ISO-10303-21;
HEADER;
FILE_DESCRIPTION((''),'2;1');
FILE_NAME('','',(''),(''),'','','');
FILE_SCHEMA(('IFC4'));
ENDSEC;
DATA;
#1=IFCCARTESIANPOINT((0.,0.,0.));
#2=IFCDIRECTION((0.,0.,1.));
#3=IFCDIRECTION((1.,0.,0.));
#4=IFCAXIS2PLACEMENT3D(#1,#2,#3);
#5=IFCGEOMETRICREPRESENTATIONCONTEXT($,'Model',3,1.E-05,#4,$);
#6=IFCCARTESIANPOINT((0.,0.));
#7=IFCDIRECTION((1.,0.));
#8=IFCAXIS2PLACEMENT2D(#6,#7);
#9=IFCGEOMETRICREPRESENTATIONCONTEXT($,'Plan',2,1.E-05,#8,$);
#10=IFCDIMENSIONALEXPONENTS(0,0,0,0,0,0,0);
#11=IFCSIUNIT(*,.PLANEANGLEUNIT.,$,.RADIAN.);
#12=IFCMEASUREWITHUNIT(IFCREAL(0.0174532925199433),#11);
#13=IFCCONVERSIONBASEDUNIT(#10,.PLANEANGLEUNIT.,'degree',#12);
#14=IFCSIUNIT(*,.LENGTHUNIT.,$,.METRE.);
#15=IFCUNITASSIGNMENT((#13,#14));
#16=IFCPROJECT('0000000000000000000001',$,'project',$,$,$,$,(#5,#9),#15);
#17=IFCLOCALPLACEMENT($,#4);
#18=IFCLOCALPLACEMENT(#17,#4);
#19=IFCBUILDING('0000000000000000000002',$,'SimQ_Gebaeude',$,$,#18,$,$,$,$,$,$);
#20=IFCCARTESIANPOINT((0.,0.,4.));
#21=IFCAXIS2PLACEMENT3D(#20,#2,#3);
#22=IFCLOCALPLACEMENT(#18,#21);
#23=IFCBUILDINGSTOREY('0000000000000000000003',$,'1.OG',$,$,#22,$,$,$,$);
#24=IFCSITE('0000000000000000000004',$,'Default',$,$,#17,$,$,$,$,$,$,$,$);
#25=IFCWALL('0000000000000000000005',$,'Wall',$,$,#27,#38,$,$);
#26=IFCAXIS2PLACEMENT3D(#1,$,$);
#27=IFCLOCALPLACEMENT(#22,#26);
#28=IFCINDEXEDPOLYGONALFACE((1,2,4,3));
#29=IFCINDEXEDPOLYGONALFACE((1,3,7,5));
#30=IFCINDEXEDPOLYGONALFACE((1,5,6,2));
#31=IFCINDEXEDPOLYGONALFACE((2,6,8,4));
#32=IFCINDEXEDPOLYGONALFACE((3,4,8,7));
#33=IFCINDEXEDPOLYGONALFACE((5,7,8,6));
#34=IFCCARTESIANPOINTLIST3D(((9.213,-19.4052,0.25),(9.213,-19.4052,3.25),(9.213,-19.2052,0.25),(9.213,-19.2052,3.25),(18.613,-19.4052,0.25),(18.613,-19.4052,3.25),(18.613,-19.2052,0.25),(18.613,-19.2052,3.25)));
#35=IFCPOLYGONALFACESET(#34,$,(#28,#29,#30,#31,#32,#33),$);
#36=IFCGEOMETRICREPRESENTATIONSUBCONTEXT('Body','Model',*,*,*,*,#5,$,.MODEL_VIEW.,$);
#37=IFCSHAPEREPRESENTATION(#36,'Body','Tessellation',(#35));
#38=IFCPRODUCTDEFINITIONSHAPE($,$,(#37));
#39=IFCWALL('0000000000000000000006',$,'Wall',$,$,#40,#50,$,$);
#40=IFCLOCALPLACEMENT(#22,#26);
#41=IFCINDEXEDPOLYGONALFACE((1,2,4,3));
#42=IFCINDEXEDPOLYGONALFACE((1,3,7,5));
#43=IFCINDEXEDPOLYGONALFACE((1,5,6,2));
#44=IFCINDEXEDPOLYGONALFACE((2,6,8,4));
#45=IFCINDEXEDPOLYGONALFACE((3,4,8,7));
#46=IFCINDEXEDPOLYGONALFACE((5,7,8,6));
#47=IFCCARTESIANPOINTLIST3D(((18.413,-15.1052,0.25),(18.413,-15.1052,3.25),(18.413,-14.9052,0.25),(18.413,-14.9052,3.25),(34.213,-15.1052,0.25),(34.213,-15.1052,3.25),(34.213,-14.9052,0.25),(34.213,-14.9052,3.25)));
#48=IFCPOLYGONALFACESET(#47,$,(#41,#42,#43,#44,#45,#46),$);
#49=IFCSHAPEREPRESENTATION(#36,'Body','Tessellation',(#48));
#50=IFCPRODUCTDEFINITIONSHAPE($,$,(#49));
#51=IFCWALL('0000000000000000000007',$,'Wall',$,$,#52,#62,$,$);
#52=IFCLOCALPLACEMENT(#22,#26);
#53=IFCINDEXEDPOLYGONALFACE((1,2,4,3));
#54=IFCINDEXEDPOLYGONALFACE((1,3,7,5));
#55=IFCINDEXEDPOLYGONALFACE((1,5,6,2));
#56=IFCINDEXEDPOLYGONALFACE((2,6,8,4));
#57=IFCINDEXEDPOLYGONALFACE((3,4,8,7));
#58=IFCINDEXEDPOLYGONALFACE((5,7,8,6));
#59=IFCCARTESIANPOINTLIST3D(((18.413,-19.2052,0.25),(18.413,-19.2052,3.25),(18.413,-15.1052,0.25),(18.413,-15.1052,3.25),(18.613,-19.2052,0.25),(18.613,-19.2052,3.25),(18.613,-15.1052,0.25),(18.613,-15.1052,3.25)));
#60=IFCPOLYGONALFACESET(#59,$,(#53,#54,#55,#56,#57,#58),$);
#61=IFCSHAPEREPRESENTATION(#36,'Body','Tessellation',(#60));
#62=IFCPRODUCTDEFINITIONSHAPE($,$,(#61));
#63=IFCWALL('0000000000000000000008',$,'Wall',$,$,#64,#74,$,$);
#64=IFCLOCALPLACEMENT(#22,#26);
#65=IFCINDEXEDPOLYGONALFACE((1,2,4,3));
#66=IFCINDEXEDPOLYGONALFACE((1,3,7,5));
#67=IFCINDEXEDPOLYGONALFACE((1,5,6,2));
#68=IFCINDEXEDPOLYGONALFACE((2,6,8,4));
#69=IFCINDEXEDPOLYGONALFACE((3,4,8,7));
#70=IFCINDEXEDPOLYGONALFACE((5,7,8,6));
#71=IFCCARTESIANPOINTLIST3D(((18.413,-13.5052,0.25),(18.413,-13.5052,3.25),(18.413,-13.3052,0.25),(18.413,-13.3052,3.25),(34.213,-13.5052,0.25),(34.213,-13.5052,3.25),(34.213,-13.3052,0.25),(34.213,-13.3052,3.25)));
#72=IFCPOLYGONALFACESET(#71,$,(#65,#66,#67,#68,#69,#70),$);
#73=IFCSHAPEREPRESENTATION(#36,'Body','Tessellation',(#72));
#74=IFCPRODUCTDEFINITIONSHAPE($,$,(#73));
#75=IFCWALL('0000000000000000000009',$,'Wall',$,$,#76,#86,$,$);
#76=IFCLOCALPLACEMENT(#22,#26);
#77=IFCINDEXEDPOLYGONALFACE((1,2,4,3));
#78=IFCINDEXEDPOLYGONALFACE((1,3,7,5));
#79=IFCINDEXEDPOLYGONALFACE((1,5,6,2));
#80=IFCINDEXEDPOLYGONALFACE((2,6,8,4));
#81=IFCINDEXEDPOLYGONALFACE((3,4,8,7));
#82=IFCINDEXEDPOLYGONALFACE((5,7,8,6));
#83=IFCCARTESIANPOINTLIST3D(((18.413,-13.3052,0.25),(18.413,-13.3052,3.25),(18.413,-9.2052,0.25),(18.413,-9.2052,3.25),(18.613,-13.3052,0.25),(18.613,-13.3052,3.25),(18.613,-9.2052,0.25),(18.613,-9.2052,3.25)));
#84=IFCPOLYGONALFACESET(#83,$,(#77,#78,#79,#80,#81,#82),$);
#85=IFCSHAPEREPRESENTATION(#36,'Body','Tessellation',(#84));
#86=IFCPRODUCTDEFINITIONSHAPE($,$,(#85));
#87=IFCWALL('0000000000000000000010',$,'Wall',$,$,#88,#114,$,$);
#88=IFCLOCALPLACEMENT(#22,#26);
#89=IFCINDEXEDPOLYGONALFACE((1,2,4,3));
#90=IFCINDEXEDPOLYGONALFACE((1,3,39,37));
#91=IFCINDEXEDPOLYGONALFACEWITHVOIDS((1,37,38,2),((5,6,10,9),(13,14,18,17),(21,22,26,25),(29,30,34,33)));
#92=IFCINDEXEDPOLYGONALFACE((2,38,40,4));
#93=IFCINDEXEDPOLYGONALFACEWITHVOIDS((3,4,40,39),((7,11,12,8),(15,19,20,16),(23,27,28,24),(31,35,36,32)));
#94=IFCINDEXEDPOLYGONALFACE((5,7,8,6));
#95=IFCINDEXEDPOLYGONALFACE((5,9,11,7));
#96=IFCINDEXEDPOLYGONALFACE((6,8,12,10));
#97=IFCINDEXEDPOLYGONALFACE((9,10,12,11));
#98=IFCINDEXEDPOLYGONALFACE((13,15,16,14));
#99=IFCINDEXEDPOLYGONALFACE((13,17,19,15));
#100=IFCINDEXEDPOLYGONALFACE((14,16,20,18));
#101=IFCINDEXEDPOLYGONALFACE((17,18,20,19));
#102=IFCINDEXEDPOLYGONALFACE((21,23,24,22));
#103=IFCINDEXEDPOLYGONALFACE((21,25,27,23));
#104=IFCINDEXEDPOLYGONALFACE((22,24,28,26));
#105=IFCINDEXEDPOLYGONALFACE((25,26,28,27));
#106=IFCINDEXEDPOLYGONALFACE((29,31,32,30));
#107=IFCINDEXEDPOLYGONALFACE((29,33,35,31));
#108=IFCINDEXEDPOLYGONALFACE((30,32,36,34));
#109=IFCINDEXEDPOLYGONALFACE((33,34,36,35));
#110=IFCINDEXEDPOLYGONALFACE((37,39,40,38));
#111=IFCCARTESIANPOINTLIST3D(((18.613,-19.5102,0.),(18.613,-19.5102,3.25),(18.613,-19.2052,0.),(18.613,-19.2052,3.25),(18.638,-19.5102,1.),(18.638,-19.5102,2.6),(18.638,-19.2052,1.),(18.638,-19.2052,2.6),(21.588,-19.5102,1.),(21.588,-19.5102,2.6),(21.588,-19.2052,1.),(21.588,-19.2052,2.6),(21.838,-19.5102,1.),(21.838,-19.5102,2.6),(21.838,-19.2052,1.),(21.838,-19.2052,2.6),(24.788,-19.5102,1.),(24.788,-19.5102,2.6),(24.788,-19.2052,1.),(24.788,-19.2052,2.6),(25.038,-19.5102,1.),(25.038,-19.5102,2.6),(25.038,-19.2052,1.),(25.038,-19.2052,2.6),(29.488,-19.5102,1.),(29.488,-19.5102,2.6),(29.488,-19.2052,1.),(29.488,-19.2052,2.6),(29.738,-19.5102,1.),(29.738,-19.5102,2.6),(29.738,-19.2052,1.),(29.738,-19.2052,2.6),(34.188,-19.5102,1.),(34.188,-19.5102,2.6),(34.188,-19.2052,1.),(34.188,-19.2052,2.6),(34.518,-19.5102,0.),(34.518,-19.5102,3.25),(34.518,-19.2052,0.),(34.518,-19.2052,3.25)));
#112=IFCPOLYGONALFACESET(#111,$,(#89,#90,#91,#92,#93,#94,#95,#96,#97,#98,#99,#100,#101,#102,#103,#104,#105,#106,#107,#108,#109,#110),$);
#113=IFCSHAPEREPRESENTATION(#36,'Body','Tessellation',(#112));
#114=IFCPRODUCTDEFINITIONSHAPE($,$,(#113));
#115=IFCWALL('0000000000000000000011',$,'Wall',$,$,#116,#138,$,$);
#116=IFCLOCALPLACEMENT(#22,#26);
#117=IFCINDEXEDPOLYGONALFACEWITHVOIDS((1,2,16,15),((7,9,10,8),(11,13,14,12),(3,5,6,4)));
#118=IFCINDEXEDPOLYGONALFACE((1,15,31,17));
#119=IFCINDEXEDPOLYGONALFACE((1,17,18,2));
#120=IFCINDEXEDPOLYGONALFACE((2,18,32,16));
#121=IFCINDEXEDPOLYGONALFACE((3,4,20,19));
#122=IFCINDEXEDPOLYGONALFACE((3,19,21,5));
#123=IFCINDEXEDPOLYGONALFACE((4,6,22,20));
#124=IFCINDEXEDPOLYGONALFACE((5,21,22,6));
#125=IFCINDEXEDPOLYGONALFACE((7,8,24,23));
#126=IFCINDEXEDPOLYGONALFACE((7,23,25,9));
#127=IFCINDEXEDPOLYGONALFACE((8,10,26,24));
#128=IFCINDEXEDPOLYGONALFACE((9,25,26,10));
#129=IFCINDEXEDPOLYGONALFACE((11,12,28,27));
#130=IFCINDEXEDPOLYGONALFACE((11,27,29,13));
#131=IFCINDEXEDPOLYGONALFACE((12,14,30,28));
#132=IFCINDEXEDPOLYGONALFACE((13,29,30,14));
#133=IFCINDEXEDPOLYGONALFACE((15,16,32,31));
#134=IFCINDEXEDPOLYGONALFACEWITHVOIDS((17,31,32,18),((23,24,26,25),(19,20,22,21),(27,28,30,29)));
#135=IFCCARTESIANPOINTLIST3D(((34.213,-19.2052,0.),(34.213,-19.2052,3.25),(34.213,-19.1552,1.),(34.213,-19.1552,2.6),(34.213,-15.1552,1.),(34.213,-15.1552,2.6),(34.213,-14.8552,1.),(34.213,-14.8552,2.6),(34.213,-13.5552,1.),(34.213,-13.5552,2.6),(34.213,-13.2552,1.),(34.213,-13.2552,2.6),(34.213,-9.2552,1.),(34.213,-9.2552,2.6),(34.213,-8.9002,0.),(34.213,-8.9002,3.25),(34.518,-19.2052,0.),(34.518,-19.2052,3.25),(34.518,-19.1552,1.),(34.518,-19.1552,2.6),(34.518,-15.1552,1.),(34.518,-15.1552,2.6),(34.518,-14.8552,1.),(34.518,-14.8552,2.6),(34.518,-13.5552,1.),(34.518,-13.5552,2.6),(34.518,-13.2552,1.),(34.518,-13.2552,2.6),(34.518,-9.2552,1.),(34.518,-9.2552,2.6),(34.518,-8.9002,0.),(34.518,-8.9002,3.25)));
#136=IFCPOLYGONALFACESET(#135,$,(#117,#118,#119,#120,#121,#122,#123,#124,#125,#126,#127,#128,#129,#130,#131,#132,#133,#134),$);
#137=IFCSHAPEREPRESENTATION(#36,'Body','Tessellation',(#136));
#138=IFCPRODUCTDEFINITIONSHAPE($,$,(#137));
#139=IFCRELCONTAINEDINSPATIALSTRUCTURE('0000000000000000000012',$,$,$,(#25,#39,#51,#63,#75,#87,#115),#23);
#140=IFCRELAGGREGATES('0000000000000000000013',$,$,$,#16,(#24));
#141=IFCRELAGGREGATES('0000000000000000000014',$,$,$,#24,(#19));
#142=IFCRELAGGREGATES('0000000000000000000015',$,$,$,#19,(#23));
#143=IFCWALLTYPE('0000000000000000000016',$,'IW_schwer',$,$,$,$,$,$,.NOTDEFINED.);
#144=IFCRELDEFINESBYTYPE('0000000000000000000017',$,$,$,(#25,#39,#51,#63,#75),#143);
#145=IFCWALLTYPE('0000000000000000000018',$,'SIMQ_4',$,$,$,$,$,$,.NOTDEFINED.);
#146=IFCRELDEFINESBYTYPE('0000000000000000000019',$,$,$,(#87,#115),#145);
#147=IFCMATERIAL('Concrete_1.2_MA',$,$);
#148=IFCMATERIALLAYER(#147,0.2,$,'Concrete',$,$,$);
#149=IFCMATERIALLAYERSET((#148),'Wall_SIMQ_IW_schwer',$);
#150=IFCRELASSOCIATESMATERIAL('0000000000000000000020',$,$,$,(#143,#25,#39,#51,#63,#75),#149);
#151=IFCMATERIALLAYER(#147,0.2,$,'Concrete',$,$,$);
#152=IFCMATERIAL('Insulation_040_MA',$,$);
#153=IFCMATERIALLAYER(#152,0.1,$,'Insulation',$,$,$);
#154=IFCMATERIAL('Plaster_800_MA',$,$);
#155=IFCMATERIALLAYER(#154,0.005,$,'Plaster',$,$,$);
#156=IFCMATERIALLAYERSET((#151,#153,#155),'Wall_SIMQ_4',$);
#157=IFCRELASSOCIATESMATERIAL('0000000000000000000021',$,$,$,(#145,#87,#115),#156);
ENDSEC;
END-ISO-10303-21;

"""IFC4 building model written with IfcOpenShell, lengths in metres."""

from ifc_helpers import new_model, entity, si_unit, converted_unit, frame, origin_with_axes, origin_2d_with_axis, place, context, subcontext, project, spatial, line, indexed_curve, outline, extrude, source, transform, mapped, material, layer, layer_set, layer_usage, type_object, element, save


model = new_model("IFC4")

# Units and contexts
model_context = context("Model", 3, precision=1e-05, world=origin_with_axes())
plan_context = context("Plan", 2, precision=1e-05, world=origin_2d_with_axis())
body_context = subcontext(model_context, "Body", "Model", "MODEL_VIEW")
ifc_project = project(units=[converted_unit("PLANEANGLEUNIT", "degree", entity("IfcReal", 0.0174532925199433), si_unit("PLANEANGLEUNIT", "RADIAN"), dimensions=[0, 0, 0, 0, 0, 0, 0]), si_unit("LENGTHUNIT", "METRE")], contexts=[model_context, plan_context])

# Site, building, storey
site_placement = place(None, origin_with_axes())
site = spatial("IfcSite", under=ifc_project, at=site_placement, Name="Default")
building_placement = place(site_placement, origin_with_axes())
building = spatial("IfcBuilding", under=site, at=building_placement, Name="SimQ_Gebaeude")
storey_placement = place(building_placement, frame((0.0, 0.0, 4.0), z_axis=(0.0, 0.0, 1.0), x_axis=(1.0, 0.0, 0.0)))
storey = spatial("IfcBuildingStorey", under=building, at=storey_placement, Name="1.OG")

# Walls
ifc_material_1 = material(Name="Concrete_1.2_MA")
ifc_layer_1 = layer(ifc_material_1, 0.2, Name="Concrete")
ifc_layer_set_1 = layer_set([ifc_layer_1], Name="Wall_SIMQ_IW_schwer")
ifc_layer_usage_1 = layer_usage(ifc_layer_set_1, "AXIS2", "POSITIVE", 0.0)
wall_type_1 = type_object("IfcWallType", Name="IW_schwer", PredefinedType="NOTDEFINED", material=ifc_layer_set_1)
wall_1_placement = place(storey_placement, frame((18.613, -19.2052, 0.25), z_axis=(0.0, 0.0, 1.0), x_axis=(-1.0, 0.0, 0.0)))
element("IfcWall", 1, at=wall_1_placement, inside=storey, type_object=wall_type_1, material=ifc_layer_usage_1, Name="Wall", context=body_context, shape_type="SweptSolid", body=[
    extrude(outline(indexed_curve([(0.0, 0.0), (0.0, 0.2), (9.4, 0.2), (9.4, 0.0), (0.0, 0.0)], self_intersect=False)), origin_with_axes(), (0.0, 0.0, 1.0), 3.0),
])
ifc_layer_usage_2 = layer_usage(ifc_layer_set_1, "AXIS2", "POSITIVE", 0.0)
wall_2_placement = place(storey_placement, frame((34.213, -14.9052, 0.25), z_axis=(0.0, 0.0, 1.0), x_axis=(-1.0, 0.0, 0.0)))
element("IfcWall", 2, at=wall_2_placement, inside=storey, type_object=wall_type_1, material=ifc_layer_usage_2, Name="Wall", context=body_context, shape_type="SweptSolid", body=[
    extrude(outline(indexed_curve([(0.0, 0.0), (0.0, 0.2), (15.8, 0.2), (15.8, 0.0), (0.0, 0.0)], self_intersect=False)), origin_with_axes(), (0.0, 0.0, 1.0), 3.0),
])
ifc_layer_usage_3 = layer_usage(ifc_layer_set_1, "AXIS2", "POSITIVE", 0.0)
wall_3_placement = place(storey_placement, frame((18.613, -19.2052, 0.25), z_axis=(0.0, 0.0, 1.0), x_axis=(0.000001, 1.0, 0.0)))
element("IfcWall", 3, at=wall_3_placement, inside=storey, type_object=wall_type_1, material=ifc_layer_usage_3, Name="Wall", context=body_context, shape_type="SweptSolid", body=[
    extrude(outline(indexed_curve([(0.0, 0.0), (0.0, 0.2), (4.1, 0.2), (4.1, 0.0), (0.0, 0.0)], self_intersect=False)), origin_with_axes(), (0.0, 0.0, 1.0), 3.0),
])
ifc_layer_usage_4 = layer_usage(ifc_layer_set_1, "AXIS2", "POSITIVE", 0.0)
wall_4_placement = place(storey_placement, frame((34.213, -13.3052, 0.25), z_axis=(0.0, 0.0, 1.0), x_axis=(-1.0, 0.0, 0.0)))
element("IfcWall", 4, at=wall_4_placement, inside=storey, type_object=wall_type_1, material=ifc_layer_usage_4, Name="Wall", context=body_context, shape_type="SweptSolid", body=[
    extrude(outline(indexed_curve([(0.0, 0.0), (0.0, 0.2), (15.8, 0.2), (15.8, 0.0), (0.0, 0.0)], self_intersect=False)), origin_with_axes(), (0.0, 0.0, 1.0), 3.0),
])
ifc_layer_usage_5 = layer_usage(ifc_layer_set_1, "AXIS2", "POSITIVE", 0.0)
wall_5_placement = place(storey_placement, frame((18.613, -13.3052, 0.25), z_axis=(0.0, 0.0, 1.0), x_axis=(0.000001, 1.0, 0.0)))
element("IfcWall", 5, at=wall_5_placement, inside=storey, type_object=wall_type_1, material=ifc_layer_usage_5, Name="Wall", context=body_context, shape_type="SweptSolid", body=[
    extrude(outline(indexed_curve([(0.0, 0.0), (0.0, 0.2), (4.1, 0.2), (4.1, 0.0), (0.0, 0.0)], self_intersect=False)), origin_with_axes(), (0.0, 0.0, 1.0), 3.0),
])

# Walls, openings
ifc_layer_2 = layer(ifc_material_1, 0.2, Name="Concrete")
ifc_material_2 = material(Name="Insulation_040_MA")
ifc_layer_3 = layer(ifc_material_2, 0.1, Name="Insulation")
ifc_material_3 = material(Name="Plaster_800_MA")
ifc_layer_4 = layer(ifc_material_3, 0.005, Name="Plaster")
ifc_layer_set_2 = layer_set([ifc_layer_2, ifc_layer_3, ifc_layer_4], Name="Wall_SIMQ_4")
ifc_layer_usage_6 = layer_usage(ifc_layer_set_2, "AXIS2", "POSITIVE", 0.0)
wall_type_2 = type_object("IfcWallType", Name="SIMQ_4", PredefinedType="NOTDEFINED", material=ifc_layer_set_2)
wall_6_placement = place(storey_placement, frame((18.613, -19.5102, 0.0), z_axis=(0.0, 0.0, 1.0), x_axis=(1.0, 0.0, 0.0)))
wall_6 = element("IfcWall", 6, at=wall_6_placement, inside=storey, type_object=wall_type_2, material=ifc_layer_usage_6, Name="Wall", context=body_context, shape_type="SweptSolid", body=[
    extrude(outline(indexed_curve([(0.0, 0.0), (0.0, 0.305), (15.905, 0.305), (15.905, 0.0), (0.0, 0.0)], self_intersect=False)), origin_with_axes(), (0.0, 0.0, 1.0), 3.25),
])
shared_shape_1 = source(origin_with_axes(), body_context, "Body", "SweptSolid", [
    extrude(outline(indexed_curve([(0.0, 0.0), (4.45, 0.0), (4.45, 1.6), (0.0, 1.6)], segments=[line(1, 2, 3, 4, 1)])), frame((0.0, -0.6, 0.0), z_axis=(0.0, -1.0, 0.0), x_axis=(1.0, 0.0, 0.0)), (0.0, 0.0, -1.0), 1.2),
])
opening_1_placement = place(wall_6_placement, frame((11.125, 0.0, 1.0), z_axis=(0.0, 0.0, 1.0), x_axis=(1.0, 0.0, 0.0)))
element("IfcOpeningElement", 7, at=opening_1_placement, cuts=wall_6, PredefinedType="OPENING", context=body_context, shape_type="MappedRepresentation", body=[
    mapped(shared_shape_1, transform((0.0, 0.0, 0.0), x_axis=(1.0, 0.0, 0.0), y_axis=(0.0, 1.0, 0.0), z_axis=(0.0, 0.0, 1.0), scale=1.0)),
])
opening_2_placement = place(wall_6_placement, frame((6.425, 0.0, 1.0), z_axis=(0.0, 0.0, 1.0), x_axis=(1.0, 0.0, 0.0)))
element("IfcOpeningElement", 8, at=opening_2_placement, cuts=wall_6, PredefinedType="OPENING", context=body_context, shape_type="MappedRepresentation", body=[
    mapped(shared_shape_1, transform((0.0, 0.0, 0.0), x_axis=(1.0, 0.0, 0.0), y_axis=(0.0, 1.0, 0.0), z_axis=(0.0, 0.0, 1.0), scale=1.0)),
])
shared_shape_2 = source(origin_with_axes(), body_context, "Body", "SweptSolid", [
    extrude(outline(indexed_curve([(0.0, 0.0), (2.95, 0.0), (2.95, 1.6), (0.0, 1.6)], segments=[line(1, 2, 3, 4, 1)])), frame((0.0, -0.6, 0.0), z_axis=(0.0, -1.0, 0.0), x_axis=(1.0, 0.0, 0.0)), (0.0, 0.0, -1.0), 1.2),
])
opening_3_placement = place(wall_6_placement, frame((3.225, 0.0, 1.0), z_axis=(0.0, 0.0, 1.0), x_axis=(1.0, 0.0, 0.0)))
element("IfcOpeningElement", 9, at=opening_3_placement, cuts=wall_6, PredefinedType="OPENING", context=body_context, shape_type="MappedRepresentation", body=[
    mapped(shared_shape_2, transform((0.0, 0.0, 0.0), x_axis=(1.0, 0.0, 0.0), y_axis=(0.0, 1.0, 0.0), z_axis=(0.0, 0.0, 1.0), scale=1.0)),
])
opening_4_placement = place(wall_6_placement, frame((0.025, 0.0, 1.0), z_axis=(0.0, 0.0, 1.0), x_axis=(1.0, 0.0, 0.0)))
element("IfcOpeningElement", 10, at=opening_4_placement, cuts=wall_6, PredefinedType="OPENING", context=body_context, shape_type="MappedRepresentation", body=[
    mapped(shared_shape_2, transform((0.0, 0.0, 0.0), x_axis=(1.0, 0.0, 0.0), y_axis=(0.0, 1.0, 0.0), z_axis=(0.0, 0.0, 1.0), scale=1.0)),
])
ifc_layer_usage_7 = layer_usage(ifc_layer_set_2, "AXIS2", "POSITIVE", 0.0)
wall_7_placement = place(storey_placement, frame((34.518, -19.2052, 0.0), z_axis=(0.0, 0.0, 1.0), x_axis=(0.0, 1.0, 0.0)))
wall_7 = element("IfcWall", 11, at=wall_7_placement, inside=storey, type_object=wall_type_2, material=ifc_layer_usage_7, Name="Wall", context=body_context, shape_type="SweptSolid", body=[
    extrude(outline(indexed_curve([(0.0, 0.0), (0.0, 0.305), (10.305, 0.305), (10.305, 0.0), (0.0, 0.0)], self_intersect=False)), origin_with_axes(), (0.0, 0.0, 1.0), 3.25),
])
shared_shape_3 = source(origin_with_axes(), body_context, "Body", "SweptSolid", [
    extrude(outline(indexed_curve([(0.0, 0.0), (4.0, 0.0), (4.0, 1.6), (0.0, 1.6)], segments=[line(1, 2, 3, 4, 1)])), frame((0.0, -0.6, 0.0), z_axis=(0.0, -1.0, 0.0), x_axis=(1.0, 0.0, 0.0)), (0.0, 0.0, -1.0), 1.2),
])
opening_5_placement = place(wall_7_placement, frame((0.05, 0.0, 1.0), z_axis=(0.0, 0.0, 1.0), x_axis=(1.0, 0.0, 0.0)))
element("IfcOpeningElement", 12, at=opening_5_placement, cuts=wall_7, PredefinedType="OPENING", context=body_context, shape_type="MappedRepresentation", body=[
    mapped(shared_shape_3, transform((0.0, 0.0, 0.0), x_axis=(1.0, 0.0, 0.0), y_axis=(0.0, 1.0, 0.0), z_axis=(0.0, 0.0, 1.0), scale=1.0)),
])
opening_6_placement = place(wall_7_placement, frame((5.95, 0.0, 1.0), z_axis=(0.0, 0.0, 1.0), x_axis=(1.0, 0.0, 0.0)))
element("IfcOpeningElement", 13, at=opening_6_placement, cuts=wall_7, PredefinedType="OPENING", context=body_context, shape_type="MappedRepresentation", body=[
    mapped(shared_shape_3, transform((0.0, 0.0, 0.0), x_axis=(1.0, 0.0, 0.0), y_axis=(0.0, 1.0, 0.0), z_axis=(0.0, 0.0, 1.0), scale=1.0)),
])
shared_shape_4 = source(origin_with_axes(), body_context, "Body", "SweptSolid", [
    extrude(outline(indexed_curve([(0.0, 0.0), (1.3, 0.0), (1.3, 1.6), (0.0, 1.6)], segments=[line(1, 2, 3, 4, 1)])), frame((0.0, -0.6, 0.0), z_axis=(0.0, -1.0, 0.0), x_axis=(1.0, 0.0, 0.0)), (0.0, 0.0, -1.0), 1.2),
])
opening_7_placement = place(wall_7_placement, frame((4.35, 0.0, 1.0), z_axis=(0.0, 0.0, 1.0), x_axis=(1.0, 0.0, 0.0)))
element("IfcOpeningElement", 14, at=opening_7_placement, cuts=wall_7, PredefinedType="OPENING", context=body_context, shape_type="MappedRepresentation", body=[
    mapped(shared_shape_4, transform((0.0, 0.0, 0.0), x_axis=(1.0, 0.0, 0.0), y_axis=(0.0, 1.0, 0.0), z_axis=(0.0, 0.0, 1.0), scale=1.0)),
])

save(model, "model.ifc")
